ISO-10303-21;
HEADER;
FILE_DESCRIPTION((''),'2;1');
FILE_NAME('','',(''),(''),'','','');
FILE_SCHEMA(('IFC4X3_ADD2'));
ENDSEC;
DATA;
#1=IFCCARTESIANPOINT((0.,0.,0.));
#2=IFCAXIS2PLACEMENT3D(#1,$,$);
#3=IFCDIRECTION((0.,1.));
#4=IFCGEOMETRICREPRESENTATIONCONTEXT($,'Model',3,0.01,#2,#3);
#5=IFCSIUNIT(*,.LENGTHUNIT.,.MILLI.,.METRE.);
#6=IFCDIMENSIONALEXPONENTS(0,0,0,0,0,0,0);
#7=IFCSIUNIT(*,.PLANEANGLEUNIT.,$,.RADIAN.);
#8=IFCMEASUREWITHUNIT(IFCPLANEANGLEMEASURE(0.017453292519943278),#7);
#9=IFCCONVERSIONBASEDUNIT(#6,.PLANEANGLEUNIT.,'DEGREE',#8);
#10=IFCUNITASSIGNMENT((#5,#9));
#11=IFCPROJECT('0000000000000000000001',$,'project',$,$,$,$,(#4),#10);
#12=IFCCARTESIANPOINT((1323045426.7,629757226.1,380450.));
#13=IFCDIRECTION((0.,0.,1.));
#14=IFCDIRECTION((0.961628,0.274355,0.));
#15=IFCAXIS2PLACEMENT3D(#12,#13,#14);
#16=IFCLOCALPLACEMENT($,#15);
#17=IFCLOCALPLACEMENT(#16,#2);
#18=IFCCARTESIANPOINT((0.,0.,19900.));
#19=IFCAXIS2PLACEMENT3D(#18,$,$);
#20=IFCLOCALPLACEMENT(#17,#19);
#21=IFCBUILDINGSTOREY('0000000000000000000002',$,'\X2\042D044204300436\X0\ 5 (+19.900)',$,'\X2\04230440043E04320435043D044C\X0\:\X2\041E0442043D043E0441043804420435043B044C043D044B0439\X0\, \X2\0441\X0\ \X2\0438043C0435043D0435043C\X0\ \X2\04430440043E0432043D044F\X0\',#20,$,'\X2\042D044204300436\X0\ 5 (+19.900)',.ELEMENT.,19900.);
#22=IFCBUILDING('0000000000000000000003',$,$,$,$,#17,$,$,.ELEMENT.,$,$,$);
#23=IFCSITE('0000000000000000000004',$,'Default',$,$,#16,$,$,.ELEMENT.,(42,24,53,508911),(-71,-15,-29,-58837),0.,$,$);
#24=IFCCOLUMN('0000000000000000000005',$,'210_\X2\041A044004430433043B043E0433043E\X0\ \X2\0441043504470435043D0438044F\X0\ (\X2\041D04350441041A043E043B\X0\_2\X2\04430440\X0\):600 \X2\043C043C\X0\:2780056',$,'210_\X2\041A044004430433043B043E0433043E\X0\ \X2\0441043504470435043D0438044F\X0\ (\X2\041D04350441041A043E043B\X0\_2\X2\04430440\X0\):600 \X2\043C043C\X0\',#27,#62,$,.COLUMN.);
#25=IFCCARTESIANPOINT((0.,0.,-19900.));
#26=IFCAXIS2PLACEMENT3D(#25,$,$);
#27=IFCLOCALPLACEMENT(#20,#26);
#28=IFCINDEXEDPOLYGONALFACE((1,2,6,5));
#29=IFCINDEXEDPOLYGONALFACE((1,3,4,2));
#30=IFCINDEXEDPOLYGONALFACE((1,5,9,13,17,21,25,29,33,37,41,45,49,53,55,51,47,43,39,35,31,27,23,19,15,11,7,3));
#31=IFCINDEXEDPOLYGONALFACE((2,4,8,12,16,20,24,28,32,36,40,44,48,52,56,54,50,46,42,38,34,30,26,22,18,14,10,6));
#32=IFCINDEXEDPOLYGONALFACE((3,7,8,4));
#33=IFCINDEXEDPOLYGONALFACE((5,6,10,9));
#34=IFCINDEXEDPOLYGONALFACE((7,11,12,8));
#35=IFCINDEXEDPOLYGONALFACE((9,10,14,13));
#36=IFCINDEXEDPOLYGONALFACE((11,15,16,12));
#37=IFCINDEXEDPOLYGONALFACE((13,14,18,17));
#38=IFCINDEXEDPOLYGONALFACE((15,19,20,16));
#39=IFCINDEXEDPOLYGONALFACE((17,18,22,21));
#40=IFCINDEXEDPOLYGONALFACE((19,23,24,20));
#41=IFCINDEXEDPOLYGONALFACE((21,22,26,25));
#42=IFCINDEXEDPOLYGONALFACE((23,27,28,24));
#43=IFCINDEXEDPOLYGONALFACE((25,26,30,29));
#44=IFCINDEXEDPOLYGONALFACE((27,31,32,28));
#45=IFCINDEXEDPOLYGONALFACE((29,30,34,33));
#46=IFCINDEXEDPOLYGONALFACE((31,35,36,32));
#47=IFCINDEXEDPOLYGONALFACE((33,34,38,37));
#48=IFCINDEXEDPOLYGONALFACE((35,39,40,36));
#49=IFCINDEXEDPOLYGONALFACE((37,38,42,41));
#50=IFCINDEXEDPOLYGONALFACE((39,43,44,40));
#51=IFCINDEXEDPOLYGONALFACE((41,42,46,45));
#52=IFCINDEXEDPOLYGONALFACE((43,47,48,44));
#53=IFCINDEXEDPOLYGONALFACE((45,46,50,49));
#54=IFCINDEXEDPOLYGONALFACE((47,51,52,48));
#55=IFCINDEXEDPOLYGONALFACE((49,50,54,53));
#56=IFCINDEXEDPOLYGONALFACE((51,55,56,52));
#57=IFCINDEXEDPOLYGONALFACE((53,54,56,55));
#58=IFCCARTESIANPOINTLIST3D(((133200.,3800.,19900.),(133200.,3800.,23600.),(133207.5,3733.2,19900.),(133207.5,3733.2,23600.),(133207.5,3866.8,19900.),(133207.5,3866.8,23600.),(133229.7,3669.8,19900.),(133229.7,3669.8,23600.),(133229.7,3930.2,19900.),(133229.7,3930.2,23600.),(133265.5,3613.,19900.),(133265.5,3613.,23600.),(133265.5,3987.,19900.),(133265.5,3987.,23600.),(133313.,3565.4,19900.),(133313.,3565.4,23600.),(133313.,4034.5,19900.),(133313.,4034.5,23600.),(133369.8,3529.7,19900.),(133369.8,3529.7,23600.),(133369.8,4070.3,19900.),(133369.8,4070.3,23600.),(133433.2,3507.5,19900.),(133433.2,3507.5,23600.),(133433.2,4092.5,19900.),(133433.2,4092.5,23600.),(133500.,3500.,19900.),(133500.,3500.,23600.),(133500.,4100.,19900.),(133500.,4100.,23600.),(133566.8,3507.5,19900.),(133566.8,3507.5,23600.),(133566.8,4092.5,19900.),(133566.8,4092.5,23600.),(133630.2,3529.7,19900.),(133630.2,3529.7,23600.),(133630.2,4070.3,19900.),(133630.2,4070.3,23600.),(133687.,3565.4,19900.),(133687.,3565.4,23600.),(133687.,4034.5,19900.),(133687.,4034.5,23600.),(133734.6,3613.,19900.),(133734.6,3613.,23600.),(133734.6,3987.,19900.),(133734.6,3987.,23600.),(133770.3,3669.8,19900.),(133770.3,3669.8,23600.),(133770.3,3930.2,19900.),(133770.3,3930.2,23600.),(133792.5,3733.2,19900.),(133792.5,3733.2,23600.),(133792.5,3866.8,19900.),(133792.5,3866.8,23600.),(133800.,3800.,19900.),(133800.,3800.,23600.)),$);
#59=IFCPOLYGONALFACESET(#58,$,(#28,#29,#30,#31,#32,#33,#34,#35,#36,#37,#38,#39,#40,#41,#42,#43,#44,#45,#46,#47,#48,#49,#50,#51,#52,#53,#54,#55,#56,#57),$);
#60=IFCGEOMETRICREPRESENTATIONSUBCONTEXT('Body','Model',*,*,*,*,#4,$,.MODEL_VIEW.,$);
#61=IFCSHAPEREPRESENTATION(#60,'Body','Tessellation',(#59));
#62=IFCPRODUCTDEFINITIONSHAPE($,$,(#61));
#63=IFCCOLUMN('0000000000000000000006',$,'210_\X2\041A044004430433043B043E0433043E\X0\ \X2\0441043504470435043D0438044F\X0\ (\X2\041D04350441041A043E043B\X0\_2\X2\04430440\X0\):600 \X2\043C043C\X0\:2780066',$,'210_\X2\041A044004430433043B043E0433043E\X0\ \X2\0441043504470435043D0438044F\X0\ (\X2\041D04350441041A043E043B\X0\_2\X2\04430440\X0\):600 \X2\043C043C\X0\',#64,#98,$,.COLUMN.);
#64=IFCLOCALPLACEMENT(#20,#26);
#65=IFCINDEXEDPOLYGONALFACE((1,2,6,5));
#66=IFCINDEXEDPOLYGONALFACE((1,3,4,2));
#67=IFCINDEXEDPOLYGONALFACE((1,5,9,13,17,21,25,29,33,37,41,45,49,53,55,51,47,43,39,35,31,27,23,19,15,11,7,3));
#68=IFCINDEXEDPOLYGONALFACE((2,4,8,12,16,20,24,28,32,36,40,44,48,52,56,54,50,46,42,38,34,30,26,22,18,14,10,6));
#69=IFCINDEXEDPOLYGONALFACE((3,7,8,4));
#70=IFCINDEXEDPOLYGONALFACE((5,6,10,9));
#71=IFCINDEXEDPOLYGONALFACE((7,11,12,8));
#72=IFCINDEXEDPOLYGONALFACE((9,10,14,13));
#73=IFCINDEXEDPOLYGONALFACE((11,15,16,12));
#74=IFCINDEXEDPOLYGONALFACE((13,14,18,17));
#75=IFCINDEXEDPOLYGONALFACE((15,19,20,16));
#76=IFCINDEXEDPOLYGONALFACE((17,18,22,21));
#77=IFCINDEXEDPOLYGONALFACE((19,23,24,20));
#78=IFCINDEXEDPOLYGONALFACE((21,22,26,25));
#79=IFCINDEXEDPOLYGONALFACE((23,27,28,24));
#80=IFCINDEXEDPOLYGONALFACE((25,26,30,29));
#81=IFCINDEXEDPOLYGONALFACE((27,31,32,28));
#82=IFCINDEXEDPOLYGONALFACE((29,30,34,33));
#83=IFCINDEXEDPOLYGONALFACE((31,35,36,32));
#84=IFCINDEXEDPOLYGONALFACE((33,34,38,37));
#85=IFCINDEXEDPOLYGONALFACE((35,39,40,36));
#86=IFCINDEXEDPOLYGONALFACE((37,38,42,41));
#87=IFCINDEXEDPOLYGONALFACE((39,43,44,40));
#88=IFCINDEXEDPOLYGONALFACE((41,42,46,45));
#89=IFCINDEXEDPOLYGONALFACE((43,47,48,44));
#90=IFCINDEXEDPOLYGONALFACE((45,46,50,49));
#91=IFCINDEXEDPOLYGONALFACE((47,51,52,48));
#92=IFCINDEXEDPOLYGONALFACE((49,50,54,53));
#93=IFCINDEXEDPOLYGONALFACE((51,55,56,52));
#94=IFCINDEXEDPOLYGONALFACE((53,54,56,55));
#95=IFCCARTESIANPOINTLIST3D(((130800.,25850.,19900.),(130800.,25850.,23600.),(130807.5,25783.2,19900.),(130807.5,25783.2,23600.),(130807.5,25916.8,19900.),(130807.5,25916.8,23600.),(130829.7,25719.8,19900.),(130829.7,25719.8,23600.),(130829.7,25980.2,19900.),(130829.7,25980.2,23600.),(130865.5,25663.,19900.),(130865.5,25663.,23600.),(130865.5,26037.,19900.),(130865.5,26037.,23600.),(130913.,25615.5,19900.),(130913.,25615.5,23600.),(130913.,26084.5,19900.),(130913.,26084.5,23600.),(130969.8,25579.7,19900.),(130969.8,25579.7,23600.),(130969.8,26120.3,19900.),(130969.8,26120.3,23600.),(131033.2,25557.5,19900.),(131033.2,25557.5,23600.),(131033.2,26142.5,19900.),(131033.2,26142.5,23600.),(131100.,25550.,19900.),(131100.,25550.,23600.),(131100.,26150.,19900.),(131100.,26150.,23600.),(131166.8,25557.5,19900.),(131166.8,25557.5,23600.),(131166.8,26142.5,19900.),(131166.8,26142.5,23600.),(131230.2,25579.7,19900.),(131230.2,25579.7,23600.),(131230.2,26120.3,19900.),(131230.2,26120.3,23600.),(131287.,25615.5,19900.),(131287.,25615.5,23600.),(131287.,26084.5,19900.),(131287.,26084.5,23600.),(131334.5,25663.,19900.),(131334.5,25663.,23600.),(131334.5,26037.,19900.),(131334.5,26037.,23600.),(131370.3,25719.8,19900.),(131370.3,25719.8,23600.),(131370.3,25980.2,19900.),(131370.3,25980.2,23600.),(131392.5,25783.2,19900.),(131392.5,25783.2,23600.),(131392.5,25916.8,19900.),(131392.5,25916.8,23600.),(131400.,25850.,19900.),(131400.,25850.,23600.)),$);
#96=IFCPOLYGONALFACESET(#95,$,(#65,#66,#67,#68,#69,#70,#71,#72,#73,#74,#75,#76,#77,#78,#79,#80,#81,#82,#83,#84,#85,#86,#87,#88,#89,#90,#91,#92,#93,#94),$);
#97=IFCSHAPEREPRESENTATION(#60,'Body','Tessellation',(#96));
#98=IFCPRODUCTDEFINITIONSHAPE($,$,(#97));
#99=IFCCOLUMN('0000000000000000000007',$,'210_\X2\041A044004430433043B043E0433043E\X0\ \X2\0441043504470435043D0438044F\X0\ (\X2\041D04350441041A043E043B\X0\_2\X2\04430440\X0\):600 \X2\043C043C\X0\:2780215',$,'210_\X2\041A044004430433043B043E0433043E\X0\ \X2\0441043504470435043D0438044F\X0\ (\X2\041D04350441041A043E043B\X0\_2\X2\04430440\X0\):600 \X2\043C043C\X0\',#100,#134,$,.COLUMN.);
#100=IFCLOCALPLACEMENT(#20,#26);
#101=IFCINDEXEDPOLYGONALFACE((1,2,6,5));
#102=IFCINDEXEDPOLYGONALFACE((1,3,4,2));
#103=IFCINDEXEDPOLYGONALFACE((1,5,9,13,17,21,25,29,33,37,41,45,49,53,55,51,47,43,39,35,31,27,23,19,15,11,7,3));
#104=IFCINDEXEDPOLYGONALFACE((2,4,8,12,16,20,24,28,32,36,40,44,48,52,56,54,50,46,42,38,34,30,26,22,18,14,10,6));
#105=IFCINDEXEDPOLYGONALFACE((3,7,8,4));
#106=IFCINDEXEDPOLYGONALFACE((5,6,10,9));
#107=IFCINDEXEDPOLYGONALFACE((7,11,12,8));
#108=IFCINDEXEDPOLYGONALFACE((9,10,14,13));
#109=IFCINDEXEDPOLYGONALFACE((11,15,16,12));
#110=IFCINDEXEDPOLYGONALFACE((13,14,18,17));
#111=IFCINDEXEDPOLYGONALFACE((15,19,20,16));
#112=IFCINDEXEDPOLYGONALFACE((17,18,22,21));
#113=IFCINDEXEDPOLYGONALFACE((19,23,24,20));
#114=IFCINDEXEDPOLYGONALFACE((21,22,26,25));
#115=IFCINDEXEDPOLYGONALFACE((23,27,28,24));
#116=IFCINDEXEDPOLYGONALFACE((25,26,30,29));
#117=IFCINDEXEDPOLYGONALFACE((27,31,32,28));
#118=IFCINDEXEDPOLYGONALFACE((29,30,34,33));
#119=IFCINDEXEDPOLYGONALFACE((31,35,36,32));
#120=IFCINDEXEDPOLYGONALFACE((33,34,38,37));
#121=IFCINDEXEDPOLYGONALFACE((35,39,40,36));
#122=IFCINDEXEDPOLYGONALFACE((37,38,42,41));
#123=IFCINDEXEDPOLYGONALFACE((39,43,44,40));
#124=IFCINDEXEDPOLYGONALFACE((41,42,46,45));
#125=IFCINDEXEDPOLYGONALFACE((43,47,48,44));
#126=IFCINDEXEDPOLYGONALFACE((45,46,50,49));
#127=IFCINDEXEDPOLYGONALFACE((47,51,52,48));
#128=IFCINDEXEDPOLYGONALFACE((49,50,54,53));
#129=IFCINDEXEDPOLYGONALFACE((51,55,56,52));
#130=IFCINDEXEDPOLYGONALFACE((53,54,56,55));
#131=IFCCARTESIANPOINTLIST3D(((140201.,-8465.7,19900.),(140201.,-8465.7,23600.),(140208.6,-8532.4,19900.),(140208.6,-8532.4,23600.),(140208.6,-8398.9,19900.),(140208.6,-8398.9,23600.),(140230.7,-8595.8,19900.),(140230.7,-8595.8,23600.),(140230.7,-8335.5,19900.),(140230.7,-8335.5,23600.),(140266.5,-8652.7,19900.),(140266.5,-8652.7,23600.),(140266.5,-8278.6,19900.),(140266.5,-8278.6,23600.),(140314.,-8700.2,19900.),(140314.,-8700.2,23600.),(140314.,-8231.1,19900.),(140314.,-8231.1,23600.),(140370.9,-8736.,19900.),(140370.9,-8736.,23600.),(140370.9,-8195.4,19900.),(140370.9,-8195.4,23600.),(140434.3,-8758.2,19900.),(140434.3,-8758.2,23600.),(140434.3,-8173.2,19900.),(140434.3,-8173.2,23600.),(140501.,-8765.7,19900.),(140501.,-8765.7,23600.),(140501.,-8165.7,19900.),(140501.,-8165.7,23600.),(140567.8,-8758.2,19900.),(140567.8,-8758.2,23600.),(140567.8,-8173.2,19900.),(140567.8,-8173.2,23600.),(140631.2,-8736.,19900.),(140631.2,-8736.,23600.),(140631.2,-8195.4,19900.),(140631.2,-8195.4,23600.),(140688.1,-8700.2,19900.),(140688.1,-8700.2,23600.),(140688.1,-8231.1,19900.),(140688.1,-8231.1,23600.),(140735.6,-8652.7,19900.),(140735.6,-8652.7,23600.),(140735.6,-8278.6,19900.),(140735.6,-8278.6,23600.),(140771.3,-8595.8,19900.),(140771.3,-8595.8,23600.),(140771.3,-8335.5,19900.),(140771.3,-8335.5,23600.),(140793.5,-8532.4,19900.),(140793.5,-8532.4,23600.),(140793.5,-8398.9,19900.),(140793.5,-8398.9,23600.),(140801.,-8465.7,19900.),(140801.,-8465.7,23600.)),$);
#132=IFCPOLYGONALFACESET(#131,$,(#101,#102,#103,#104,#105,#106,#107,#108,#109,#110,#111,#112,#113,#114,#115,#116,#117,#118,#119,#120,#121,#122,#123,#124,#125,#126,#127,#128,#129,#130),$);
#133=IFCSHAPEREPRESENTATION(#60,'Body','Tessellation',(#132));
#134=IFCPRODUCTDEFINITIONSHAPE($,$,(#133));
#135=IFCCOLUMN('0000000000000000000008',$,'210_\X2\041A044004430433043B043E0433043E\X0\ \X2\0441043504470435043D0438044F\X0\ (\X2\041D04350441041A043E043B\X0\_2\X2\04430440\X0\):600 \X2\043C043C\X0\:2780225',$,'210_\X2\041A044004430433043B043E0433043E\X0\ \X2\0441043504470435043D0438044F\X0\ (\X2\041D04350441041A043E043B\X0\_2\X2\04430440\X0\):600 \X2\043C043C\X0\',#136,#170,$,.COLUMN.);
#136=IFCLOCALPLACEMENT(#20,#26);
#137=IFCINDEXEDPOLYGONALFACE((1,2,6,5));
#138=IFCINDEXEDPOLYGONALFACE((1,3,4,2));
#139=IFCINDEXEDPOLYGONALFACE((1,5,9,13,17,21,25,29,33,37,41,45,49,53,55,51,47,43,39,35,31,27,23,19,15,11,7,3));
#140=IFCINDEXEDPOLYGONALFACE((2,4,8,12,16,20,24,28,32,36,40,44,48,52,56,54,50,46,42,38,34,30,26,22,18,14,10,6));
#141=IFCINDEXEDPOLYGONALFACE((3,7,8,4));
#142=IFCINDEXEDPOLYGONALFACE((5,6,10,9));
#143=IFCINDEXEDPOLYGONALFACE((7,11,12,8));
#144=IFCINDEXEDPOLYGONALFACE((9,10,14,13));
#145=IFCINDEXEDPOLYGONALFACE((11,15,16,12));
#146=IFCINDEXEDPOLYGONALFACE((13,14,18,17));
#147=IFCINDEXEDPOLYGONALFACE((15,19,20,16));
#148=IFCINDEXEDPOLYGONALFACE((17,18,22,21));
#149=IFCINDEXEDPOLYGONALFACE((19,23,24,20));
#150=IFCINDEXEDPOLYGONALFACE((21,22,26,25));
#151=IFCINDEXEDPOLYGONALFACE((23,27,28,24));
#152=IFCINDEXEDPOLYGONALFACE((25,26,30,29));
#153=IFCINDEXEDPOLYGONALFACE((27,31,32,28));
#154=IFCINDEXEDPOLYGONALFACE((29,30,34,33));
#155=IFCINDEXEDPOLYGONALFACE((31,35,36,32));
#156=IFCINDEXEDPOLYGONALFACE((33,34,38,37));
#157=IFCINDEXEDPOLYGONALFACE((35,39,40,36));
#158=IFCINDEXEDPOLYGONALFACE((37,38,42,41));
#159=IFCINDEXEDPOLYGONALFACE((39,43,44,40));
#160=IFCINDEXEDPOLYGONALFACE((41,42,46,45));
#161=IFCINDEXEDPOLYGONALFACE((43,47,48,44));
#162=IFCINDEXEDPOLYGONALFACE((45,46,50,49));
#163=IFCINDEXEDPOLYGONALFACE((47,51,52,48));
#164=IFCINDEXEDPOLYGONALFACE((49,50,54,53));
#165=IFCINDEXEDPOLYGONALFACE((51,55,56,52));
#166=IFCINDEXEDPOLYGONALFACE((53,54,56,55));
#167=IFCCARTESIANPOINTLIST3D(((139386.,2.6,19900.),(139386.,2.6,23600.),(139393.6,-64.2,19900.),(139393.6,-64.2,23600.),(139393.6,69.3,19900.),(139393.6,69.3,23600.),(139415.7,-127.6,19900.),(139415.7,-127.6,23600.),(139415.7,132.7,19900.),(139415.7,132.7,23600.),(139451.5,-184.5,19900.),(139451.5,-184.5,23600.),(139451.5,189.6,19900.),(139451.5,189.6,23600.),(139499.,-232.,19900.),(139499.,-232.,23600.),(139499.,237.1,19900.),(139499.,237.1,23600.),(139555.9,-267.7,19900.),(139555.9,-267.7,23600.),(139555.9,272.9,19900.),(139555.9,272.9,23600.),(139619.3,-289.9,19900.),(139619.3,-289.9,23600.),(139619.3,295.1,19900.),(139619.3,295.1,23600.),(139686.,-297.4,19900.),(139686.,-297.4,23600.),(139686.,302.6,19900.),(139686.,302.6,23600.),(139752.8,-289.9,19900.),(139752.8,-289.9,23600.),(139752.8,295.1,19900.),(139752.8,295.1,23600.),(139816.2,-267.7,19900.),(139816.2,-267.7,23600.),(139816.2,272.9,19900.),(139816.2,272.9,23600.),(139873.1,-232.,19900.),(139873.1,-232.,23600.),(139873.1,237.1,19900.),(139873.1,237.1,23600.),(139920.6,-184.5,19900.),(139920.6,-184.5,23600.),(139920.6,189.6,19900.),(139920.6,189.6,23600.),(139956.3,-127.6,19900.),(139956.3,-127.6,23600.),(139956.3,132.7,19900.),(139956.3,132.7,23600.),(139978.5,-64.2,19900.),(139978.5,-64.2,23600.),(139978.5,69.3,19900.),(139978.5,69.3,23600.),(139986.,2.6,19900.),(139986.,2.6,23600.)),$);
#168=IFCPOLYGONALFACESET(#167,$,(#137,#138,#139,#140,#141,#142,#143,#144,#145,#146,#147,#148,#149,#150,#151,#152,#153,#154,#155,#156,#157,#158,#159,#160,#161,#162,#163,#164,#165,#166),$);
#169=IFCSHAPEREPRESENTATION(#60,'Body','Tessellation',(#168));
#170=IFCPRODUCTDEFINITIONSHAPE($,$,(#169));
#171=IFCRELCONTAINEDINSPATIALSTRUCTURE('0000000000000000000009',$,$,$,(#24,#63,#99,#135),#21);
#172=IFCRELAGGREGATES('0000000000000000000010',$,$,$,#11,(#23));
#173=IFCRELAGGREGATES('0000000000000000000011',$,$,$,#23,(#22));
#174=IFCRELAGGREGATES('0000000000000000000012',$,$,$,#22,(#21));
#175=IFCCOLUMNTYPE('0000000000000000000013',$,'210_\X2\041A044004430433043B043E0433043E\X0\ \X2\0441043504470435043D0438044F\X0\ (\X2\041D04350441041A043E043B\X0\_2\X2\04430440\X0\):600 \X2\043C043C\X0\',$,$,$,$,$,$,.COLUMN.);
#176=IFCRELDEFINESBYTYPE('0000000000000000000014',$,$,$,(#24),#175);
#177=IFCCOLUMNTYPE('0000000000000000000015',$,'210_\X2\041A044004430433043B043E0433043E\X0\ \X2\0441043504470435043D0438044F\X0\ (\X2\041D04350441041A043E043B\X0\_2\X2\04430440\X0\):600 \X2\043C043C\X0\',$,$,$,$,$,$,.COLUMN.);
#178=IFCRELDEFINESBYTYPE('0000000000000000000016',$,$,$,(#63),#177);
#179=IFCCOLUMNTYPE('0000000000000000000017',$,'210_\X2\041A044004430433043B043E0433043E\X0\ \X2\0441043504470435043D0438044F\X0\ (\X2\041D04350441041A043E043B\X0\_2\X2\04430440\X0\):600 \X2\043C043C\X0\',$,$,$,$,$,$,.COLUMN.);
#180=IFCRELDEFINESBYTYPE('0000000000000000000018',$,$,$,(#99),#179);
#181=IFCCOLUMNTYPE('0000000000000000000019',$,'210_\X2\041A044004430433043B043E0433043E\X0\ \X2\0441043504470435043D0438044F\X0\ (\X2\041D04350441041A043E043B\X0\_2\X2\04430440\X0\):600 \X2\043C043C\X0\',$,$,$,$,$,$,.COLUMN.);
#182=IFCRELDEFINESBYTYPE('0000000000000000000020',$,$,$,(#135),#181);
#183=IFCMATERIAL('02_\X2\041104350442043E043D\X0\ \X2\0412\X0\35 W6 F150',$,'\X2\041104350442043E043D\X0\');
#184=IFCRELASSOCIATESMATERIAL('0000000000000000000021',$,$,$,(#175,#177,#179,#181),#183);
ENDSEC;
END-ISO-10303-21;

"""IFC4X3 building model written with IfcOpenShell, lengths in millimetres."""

from ifc_helpers import new_model, entity, si_unit, converted_unit, direction, frame, frame_2d, origin, origin_2d_with_axis, place, context, subcontext, project, spatial, circle, extrude, source, transform, mapped, material, material_profile, profile_set, type_object, type_shapes, element, save


model = new_model("IFC4X3")

# Units and contexts
model_context = context("Model", 3, precision=0.01, world=origin(), true_north=direction((0.0, 1.0)))
body_context = subcontext(model_context, "Body", "Model", "MODEL_VIEW")
ifc_project = project(units=[si_unit("LENGTHUNIT", "METRE", prefix="MILLI"), converted_unit("PLANEANGLEUNIT", "DEGREE", entity("IfcPlaneAngleMeasure", 0.017453292519943278), si_unit("PLANEANGLEUNIT", "RADIAN"), dimensions=[0, 0, 0, 0, 0, 0, 0])], contexts=[model_context])

# Site, building, storey
site_placement = place(None, frame((1323045426.7, 629757226.1, 380450.0), z_axis=(0.0, 0.0, 1.0), x_axis=(0.961628, 0.274355, 0.0)))
site = spatial("IfcSite", under=ifc_project, at=site_placement, Name="Default", CompositionType="ELEMENT", RefLatitude=(42, 24, 53, 508911), RefLongitude=(-71, -15, -29, -58837), RefElevation=0.0)
building_placement = place(site_placement, origin())
building = spatial("IfcBuilding", under=site, at=building_placement, CompositionType="ELEMENT")
storey_placement = place(building_placement, frame((0.0, 0.0, 19900.0)))
storey = spatial("IfcBuildingStorey", under=building, at=storey_placement, Name="Этаж 5 (+19.900)", ObjectType="Уровень:Относительный, с именем уровня", LongName="Этаж 5 (+19.900)", CompositionType="ELEMENT", Elevation=19900.0)

# Columns
ifc_material = material(Name="02_Бетон В35 W6 F150", Category="Бетон")
ifc_material_profile = material_profile(ifc_material, circle(Radius=300.0, at=origin_2d_with_axis()), Name="600 мм")
ifc_profile_set = profile_set([ifc_material_profile], Name="600 мм")
column_type_1 = type_object("IfcColumnType", Name="210_Круглого сечения (НесКол_2ур):600 мм", PredefinedType="COLUMN", material=ifc_profile_set)
shared_shape_1 = source(origin(), body_context, "Body", "SweptSolid", [
    extrude(circle(Radius=300.0, at=frame_2d((0.0, 0.0), x_axis=(1.0, 0.0))), frame((133500.0, 3800.0, 19900.0)), (0.0, 0.0, 1.0), 3700.0),
])
type_shapes(column_type_1, [shared_shape_1])
column_1_placement = place(storey_placement, frame((0.0, 0.0, -19900.0)))
element("IfcColumn", 1, at=column_1_placement, inside=storey, type_object=column_type_1, Name="210_Круглого сечения (НесКол_2ур):600 мм:2780056", ObjectType="210_Круглого сечения (НесКол_2ур):600 мм", PredefinedType="COLUMN", context=body_context, shape_type="MappedRepresentation", body=[
    mapped(shared_shape_1, transform((0.0, 0.0, 0.0), scale=1.0)),
])
column_type_2 = type_object("IfcColumnType", Name="210_Круглого сечения (НесКол_2ур):600 мм", PredefinedType="COLUMN", material=ifc_profile_set)
shared_shape_2 = source(origin(), body_context, "Body", "SweptSolid", [
    extrude(circle(Radius=300.0, at=origin_2d_with_axis()), frame((131100.0, 25850.0, 19900.0)), (0.0, 0.0, 1.0), 3700.0),
])
type_shapes(column_type_2, [shared_shape_2])
column_2_placement = place(storey_placement, frame((0.0, 0.0, -19900.0)))
element("IfcColumn", 2, at=column_2_placement, inside=storey, type_object=column_type_2, Name="210_Круглого сечения (НесКол_2ур):600 мм:2780066", ObjectType="210_Круглого сечения (НесКол_2ур):600 мм", PredefinedType="COLUMN", context=body_context, shape_type="MappedRepresentation", body=[
    mapped(shared_shape_2, transform((0.0, 0.0, 0.0), scale=1.0)),
])
column_type_3 = type_object("IfcColumnType", Name="210_Круглого сечения (НесКол_2ур):600 мм", PredefinedType="COLUMN", material=ifc_profile_set)
shared_shape_3 = source(origin(), body_context, "Body", "SweptSolid", [
    extrude(circle(Radius=300.0, at=origin_2d_with_axis()), frame((140501.0, -8465.7, 19900.0)), (0.0, 0.0, 1.0), 3700.0),
])
type_shapes(column_type_3, [shared_shape_3])
column_3_placement = place(storey_placement, frame((0.0, 0.0, -19900.0)))
element("IfcColumn", 3, at=column_3_placement, inside=storey, type_object=column_type_3, Name="210_Круглого сечения (НесКол_2ур):600 мм:2780215", ObjectType="210_Круглого сечения (НесКол_2ур):600 мм", PredefinedType="COLUMN", context=body_context, shape_type="MappedRepresentation", body=[
    mapped(shared_shape_3, transform((0.0, 0.0, 0.0), scale=1.0)),
])
column_type_4 = type_object("IfcColumnType", Name="210_Круглого сечения (НесКол_2ур):600 мм", PredefinedType="COLUMN", material=ifc_profile_set)
shared_shape_4 = source(origin(), body_context, "Body", "SweptSolid", [
    extrude(circle(Radius=300.0, at=frame_2d((0.0, 0.0), x_axis=(1.0, 0.0))), frame((139686.0, 2.6, 19900.0)), (0.0, 0.0, 1.0), 3700.0),
])
type_shapes(column_type_4, [shared_shape_4])
column_4_placement = place(storey_placement, frame((0.0, 0.0, -19900.0)))
element("IfcColumn", 4, at=column_4_placement, inside=storey, type_object=column_type_4, Name="210_Круглого сечения (НесКол_2ур):600 мм:2780225", ObjectType="210_Круглого сечения (НесКол_2ур):600 мм", PredefinedType="COLUMN", context=body_context, shape_type="MappedRepresentation", body=[
    mapped(shared_shape_4, transform((0.0, 0.0, 0.0), scale=1.0)),
])

save(model, "model.ifc")
